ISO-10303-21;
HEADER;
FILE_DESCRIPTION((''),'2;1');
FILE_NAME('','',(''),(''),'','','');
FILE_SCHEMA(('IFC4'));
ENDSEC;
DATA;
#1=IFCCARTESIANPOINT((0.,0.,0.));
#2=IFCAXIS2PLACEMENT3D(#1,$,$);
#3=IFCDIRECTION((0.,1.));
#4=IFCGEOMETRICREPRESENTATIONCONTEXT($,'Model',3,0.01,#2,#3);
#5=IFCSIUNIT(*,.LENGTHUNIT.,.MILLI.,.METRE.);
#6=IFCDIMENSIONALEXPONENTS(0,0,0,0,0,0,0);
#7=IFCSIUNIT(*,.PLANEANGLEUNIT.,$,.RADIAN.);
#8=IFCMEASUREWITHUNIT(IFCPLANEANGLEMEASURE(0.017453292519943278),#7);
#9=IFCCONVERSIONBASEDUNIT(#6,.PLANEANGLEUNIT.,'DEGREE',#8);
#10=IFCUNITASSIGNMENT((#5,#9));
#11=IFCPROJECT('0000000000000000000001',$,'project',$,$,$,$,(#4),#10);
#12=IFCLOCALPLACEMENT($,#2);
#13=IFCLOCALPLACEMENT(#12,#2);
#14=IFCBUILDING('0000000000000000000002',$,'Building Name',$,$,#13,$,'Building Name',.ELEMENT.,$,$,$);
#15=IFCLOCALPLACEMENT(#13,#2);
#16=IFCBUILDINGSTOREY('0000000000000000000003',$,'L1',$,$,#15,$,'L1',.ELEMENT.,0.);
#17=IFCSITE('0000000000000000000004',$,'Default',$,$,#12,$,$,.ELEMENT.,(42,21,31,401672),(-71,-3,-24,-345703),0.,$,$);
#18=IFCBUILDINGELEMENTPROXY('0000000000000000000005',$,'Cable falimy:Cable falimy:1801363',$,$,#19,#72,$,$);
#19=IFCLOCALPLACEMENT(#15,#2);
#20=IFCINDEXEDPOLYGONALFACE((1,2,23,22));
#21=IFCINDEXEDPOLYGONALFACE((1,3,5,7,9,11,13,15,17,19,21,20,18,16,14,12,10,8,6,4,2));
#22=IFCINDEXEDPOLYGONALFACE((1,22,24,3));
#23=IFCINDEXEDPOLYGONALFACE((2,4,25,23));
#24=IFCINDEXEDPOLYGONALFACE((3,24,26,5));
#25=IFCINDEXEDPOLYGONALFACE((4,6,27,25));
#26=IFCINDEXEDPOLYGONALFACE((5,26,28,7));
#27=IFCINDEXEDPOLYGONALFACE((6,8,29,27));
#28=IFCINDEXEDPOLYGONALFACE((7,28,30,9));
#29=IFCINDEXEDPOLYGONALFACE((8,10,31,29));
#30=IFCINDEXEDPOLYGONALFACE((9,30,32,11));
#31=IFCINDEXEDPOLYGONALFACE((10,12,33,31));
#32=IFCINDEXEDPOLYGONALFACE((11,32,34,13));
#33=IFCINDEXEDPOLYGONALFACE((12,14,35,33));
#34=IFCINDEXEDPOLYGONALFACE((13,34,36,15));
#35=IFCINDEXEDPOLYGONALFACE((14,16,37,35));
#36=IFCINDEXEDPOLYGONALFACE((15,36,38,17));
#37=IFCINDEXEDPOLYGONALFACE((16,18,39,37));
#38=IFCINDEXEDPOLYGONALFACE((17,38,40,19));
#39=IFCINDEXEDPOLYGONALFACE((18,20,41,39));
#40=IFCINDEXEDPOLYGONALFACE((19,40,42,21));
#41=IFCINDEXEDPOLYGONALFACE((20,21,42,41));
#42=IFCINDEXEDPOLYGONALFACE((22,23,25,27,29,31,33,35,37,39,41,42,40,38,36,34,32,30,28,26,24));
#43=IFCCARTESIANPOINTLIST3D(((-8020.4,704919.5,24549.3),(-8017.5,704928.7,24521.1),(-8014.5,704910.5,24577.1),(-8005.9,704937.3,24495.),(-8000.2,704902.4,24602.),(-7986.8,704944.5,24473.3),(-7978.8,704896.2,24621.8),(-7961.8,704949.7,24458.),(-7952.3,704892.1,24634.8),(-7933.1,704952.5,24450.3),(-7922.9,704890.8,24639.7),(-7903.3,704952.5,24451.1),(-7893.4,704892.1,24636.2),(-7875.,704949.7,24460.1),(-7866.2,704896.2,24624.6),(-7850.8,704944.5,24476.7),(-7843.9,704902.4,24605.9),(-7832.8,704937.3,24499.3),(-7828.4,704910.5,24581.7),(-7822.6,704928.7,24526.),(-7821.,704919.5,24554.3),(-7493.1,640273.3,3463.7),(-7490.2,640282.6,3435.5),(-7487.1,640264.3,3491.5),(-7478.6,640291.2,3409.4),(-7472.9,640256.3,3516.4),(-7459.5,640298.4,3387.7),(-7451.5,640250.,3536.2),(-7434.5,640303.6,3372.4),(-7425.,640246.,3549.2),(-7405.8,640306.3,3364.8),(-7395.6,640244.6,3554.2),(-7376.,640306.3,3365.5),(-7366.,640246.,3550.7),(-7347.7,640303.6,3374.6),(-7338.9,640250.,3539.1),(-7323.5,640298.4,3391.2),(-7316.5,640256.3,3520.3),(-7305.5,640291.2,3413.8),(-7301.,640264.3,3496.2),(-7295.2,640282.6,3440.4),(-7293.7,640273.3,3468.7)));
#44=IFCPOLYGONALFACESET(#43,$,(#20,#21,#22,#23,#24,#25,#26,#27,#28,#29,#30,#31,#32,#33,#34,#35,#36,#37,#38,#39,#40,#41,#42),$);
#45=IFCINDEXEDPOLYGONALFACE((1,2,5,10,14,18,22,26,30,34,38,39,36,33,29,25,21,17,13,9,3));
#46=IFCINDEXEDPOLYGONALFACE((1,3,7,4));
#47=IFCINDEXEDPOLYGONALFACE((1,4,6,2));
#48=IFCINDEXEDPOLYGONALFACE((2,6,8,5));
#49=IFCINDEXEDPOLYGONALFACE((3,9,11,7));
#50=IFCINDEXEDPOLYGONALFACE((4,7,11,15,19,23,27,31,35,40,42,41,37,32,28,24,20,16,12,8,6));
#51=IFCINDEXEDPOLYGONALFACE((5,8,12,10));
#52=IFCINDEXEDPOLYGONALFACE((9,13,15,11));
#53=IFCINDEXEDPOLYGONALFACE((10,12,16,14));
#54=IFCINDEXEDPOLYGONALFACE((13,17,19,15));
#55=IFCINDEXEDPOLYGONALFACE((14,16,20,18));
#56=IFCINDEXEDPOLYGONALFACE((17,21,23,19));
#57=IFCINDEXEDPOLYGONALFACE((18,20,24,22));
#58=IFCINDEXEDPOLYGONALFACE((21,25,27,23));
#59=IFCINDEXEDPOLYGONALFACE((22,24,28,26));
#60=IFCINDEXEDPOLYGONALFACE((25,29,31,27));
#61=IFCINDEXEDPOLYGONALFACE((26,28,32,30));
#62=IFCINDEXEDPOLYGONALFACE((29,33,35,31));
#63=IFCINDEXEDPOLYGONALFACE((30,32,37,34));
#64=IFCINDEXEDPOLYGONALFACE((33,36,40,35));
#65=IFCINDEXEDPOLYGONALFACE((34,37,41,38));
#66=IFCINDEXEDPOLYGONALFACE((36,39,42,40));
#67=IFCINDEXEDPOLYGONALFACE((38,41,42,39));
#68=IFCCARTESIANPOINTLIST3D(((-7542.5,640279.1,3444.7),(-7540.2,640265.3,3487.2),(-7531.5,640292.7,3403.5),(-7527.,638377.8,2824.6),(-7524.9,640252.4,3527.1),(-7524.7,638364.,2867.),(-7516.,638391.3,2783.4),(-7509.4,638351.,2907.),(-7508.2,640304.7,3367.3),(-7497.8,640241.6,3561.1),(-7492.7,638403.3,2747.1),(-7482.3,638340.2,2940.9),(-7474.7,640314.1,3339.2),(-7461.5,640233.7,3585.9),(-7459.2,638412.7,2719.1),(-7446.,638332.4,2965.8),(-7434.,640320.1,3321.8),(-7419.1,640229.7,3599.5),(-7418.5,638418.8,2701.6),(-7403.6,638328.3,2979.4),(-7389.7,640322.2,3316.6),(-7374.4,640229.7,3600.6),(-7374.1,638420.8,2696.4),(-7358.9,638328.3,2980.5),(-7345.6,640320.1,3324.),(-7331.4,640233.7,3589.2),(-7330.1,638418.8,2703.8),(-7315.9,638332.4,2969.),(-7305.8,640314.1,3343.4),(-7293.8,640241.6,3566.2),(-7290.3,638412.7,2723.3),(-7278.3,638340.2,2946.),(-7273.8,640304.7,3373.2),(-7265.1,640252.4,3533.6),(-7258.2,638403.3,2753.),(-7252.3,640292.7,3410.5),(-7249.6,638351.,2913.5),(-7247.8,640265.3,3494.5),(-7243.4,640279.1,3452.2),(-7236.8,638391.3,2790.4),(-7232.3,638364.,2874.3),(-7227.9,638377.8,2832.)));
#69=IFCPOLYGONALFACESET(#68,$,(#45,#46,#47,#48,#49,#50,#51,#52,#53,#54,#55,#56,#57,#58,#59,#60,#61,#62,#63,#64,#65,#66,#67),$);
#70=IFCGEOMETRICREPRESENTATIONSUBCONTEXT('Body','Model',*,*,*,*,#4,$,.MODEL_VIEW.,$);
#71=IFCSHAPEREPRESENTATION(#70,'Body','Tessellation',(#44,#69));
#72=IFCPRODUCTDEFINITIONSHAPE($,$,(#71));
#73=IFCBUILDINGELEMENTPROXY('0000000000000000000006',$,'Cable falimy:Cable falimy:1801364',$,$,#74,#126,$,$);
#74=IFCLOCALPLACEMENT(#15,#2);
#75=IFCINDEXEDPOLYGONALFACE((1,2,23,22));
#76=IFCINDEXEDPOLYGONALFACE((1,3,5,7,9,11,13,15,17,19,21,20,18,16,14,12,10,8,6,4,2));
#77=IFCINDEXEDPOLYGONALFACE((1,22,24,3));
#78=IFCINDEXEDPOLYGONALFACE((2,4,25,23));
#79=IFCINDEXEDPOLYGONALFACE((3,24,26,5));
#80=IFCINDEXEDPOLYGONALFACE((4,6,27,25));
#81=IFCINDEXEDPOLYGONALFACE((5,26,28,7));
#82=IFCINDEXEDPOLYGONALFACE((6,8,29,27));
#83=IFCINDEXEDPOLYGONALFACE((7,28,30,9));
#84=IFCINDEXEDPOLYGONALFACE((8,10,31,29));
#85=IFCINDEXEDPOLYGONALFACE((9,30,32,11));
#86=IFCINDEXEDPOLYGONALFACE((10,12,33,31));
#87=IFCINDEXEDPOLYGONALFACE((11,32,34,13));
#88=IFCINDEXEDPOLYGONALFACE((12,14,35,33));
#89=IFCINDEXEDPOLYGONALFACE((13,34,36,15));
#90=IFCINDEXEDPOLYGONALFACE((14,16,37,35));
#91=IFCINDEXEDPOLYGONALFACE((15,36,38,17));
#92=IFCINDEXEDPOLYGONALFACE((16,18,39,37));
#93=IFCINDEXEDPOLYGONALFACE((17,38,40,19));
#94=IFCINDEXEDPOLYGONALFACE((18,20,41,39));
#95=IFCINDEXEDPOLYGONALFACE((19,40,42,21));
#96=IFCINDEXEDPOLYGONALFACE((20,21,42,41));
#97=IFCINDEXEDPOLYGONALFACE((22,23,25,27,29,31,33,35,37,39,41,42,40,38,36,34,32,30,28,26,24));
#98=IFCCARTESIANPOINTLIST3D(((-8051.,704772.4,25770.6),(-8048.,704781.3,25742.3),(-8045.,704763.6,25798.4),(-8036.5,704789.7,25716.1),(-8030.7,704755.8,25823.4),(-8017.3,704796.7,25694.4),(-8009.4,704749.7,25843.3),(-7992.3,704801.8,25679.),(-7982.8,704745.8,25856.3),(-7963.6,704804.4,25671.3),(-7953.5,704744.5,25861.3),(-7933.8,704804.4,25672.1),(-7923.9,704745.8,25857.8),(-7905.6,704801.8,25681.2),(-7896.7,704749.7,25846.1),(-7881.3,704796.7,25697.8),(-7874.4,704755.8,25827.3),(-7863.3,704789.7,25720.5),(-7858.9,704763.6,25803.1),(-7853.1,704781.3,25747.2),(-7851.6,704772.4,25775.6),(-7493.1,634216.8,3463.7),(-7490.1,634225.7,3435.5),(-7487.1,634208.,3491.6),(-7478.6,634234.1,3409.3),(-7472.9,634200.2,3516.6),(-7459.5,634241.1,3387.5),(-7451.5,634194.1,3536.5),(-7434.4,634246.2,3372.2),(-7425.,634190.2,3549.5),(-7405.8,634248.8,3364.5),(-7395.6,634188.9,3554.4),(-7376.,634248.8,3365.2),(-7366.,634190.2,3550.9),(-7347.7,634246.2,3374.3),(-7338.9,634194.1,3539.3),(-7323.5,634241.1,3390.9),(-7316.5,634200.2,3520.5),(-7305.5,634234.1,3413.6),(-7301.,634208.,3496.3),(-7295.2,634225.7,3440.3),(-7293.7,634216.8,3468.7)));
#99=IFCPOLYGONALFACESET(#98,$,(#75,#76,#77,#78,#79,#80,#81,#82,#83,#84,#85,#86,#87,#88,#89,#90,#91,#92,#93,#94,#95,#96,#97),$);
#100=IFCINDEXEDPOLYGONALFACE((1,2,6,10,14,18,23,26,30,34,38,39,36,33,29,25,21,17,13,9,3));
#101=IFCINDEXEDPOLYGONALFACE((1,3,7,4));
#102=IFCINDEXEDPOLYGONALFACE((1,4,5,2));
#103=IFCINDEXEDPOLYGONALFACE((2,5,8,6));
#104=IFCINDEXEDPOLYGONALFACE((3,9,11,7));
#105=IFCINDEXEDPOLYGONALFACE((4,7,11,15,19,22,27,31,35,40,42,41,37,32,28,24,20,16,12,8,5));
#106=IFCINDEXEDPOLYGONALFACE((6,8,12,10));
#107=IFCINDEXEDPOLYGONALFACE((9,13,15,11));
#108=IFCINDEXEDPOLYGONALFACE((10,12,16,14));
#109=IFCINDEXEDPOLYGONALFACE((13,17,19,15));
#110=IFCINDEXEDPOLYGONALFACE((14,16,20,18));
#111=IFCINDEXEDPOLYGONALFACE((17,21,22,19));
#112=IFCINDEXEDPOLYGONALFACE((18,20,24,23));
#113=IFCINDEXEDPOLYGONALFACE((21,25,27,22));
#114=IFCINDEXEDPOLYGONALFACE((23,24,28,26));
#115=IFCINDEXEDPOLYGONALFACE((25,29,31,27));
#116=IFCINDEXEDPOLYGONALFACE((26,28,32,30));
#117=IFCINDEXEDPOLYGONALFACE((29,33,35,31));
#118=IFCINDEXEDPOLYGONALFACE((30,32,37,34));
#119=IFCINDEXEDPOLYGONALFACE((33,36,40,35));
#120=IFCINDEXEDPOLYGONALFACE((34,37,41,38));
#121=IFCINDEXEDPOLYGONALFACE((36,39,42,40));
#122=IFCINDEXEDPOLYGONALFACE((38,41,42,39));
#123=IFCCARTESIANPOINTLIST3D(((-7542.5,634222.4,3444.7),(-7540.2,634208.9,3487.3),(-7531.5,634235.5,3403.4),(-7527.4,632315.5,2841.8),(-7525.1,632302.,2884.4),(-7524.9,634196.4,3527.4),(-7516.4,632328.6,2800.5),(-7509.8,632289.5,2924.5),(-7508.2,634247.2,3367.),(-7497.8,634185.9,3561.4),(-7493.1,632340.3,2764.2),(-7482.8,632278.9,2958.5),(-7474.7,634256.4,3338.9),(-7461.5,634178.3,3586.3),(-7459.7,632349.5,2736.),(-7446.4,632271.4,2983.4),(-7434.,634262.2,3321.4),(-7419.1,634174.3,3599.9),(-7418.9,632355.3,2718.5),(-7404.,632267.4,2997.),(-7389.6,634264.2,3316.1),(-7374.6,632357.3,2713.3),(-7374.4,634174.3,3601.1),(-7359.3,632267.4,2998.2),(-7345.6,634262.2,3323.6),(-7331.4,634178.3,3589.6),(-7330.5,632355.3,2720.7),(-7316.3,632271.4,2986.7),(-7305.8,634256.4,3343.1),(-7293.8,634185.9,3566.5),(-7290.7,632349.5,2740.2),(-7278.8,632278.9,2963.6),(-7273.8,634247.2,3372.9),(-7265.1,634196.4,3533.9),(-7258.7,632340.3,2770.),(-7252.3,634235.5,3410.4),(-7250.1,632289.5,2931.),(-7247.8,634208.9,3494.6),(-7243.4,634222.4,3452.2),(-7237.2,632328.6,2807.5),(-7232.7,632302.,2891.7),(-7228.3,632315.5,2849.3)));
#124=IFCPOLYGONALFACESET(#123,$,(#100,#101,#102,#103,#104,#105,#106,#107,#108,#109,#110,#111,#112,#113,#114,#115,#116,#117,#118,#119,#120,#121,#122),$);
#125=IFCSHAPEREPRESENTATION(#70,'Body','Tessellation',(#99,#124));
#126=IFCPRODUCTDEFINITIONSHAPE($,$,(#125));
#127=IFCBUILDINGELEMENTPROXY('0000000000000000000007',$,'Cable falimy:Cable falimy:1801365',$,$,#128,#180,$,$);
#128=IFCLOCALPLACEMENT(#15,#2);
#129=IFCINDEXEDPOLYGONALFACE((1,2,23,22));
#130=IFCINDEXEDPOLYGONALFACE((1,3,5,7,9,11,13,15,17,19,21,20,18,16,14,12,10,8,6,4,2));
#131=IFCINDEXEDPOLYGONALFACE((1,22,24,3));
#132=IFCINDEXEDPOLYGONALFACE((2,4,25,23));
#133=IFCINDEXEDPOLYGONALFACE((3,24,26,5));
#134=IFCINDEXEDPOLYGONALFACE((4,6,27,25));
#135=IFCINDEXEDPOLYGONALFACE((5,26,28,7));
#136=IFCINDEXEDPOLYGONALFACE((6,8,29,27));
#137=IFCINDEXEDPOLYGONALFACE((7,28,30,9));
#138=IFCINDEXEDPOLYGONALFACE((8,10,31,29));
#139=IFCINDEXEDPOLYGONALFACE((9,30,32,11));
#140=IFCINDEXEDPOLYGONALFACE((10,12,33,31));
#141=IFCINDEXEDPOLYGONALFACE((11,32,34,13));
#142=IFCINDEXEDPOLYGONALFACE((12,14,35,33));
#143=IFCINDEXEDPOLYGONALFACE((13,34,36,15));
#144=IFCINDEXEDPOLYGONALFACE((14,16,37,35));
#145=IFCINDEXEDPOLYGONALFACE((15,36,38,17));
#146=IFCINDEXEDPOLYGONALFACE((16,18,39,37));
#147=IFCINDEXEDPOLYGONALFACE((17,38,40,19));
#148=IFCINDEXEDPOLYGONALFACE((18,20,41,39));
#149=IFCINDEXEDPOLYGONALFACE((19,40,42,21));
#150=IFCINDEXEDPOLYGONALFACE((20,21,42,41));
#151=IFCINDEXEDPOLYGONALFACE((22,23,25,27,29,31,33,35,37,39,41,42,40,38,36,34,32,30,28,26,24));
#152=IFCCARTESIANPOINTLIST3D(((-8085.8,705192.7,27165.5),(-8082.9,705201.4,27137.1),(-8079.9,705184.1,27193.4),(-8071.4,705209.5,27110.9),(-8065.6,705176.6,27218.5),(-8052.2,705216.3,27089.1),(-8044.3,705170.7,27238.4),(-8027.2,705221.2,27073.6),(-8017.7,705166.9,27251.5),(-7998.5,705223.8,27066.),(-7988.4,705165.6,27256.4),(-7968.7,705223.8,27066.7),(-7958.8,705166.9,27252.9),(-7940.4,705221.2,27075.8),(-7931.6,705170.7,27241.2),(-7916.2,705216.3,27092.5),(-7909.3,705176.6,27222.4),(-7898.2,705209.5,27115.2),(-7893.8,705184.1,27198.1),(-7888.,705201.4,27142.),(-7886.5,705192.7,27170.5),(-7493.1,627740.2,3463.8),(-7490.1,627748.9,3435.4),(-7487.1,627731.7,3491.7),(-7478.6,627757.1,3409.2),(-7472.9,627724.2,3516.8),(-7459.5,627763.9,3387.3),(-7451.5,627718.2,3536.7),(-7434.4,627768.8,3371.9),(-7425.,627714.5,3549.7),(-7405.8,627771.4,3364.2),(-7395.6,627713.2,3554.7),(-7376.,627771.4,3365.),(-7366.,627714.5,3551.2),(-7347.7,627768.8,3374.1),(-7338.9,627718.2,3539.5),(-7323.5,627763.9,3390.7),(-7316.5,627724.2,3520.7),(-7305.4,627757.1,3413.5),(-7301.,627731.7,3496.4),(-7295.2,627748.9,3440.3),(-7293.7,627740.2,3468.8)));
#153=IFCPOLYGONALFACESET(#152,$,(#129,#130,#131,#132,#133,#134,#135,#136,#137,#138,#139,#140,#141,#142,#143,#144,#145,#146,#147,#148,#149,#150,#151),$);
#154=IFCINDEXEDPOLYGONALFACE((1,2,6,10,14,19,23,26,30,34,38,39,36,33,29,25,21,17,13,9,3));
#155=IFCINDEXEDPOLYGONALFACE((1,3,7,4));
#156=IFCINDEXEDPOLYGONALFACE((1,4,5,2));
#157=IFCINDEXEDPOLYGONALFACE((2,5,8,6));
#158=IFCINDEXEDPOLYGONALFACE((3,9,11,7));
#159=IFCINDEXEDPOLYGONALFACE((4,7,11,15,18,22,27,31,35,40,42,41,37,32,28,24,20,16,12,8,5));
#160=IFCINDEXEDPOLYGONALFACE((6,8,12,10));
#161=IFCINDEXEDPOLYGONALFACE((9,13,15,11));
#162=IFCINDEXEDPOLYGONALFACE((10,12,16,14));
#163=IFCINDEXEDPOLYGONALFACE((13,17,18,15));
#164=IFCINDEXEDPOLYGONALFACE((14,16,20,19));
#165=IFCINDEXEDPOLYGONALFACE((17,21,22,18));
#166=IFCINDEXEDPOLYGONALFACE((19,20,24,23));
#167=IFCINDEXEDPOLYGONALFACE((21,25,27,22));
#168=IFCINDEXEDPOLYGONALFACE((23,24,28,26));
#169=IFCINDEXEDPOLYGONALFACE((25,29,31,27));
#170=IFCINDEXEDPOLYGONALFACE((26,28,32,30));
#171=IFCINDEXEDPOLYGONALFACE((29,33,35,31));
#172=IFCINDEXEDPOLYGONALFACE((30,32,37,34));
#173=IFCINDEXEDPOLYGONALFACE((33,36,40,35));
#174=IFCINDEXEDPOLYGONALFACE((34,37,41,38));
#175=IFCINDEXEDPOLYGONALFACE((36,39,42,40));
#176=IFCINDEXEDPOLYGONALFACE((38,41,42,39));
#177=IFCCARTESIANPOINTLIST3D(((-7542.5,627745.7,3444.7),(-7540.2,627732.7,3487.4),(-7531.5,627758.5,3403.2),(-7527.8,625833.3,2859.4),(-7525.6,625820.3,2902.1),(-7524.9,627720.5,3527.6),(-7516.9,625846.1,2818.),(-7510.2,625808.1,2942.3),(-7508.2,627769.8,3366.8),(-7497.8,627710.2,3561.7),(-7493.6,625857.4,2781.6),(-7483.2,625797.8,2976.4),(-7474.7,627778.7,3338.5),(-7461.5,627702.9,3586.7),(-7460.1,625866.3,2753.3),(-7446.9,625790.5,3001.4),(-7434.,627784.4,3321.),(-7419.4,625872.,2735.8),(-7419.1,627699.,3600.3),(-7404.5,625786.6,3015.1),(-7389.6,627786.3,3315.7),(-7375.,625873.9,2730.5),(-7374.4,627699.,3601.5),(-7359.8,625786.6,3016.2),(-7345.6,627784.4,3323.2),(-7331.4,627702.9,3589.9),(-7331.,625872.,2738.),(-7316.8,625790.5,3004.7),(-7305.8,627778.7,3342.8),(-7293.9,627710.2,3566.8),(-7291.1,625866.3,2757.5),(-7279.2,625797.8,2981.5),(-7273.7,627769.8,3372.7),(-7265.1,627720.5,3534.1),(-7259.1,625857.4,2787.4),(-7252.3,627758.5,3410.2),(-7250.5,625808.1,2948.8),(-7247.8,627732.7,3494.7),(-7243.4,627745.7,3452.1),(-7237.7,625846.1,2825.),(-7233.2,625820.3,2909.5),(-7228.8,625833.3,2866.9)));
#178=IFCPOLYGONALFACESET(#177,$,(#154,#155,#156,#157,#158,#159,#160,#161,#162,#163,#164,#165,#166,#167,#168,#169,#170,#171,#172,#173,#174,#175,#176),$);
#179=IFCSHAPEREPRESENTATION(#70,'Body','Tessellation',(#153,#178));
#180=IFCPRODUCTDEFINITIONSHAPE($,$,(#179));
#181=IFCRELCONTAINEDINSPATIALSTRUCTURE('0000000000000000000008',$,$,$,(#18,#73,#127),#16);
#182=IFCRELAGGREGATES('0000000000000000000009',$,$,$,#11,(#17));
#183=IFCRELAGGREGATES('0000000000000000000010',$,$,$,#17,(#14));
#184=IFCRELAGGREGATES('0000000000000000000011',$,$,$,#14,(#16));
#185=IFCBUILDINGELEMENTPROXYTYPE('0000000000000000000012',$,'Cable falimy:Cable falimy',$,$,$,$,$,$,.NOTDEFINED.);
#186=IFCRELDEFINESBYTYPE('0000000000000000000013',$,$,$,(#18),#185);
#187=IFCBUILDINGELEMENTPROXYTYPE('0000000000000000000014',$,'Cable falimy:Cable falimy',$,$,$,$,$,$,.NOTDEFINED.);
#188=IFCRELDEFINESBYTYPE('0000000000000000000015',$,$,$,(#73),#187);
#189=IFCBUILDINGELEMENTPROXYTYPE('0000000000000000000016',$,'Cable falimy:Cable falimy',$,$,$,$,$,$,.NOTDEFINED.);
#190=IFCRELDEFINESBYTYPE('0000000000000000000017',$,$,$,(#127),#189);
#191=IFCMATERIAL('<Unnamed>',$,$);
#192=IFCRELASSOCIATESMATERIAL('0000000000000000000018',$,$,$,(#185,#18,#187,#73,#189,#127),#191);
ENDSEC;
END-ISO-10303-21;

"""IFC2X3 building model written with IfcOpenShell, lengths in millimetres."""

from ifc_helpers import new_model, entity, si_unit, converted_unit, direction, frame, frame_2d, origin, place, context, subcontext, project, spatial, circle, extrude, source, transform, mapped, material, type_object, type_shapes, element, save


model = new_model("IFC2X3")

# Units and contexts
model_context = context("Model", 3, precision=0.01, world=origin(), true_north=direction((0.0, 1.0)))
body_context = subcontext(model_context, "Body", "Model", "MODEL_VIEW")
ifc_project = project(units=[si_unit("LENGTHUNIT", "METRE", prefix="MILLI"), converted_unit("PLANEANGLEUNIT", "DEGREE", entity("IfcPlaneAngleMeasure", 0.017453292519943278), si_unit("PLANEANGLEUNIT", "RADIAN"), dimensions=[0, 0, 0, 0, 0, 0, 0])], contexts=[model_context])

# Site, building, storey
site_placement = place(None, origin())
site = spatial("IfcSite", under=ifc_project, at=site_placement, Name="Default", CompositionType="ELEMENT", RefLatitude=(42, 21, 31, 401672), RefLongitude=(-71, -3, -24, -345703), RefElevation=0.0)
building_placement = place(site_placement, origin())
building = spatial("IfcBuilding", under=site, at=building_placement, Name="Building Name", LongName="Building Name", CompositionType="ELEMENT")
storey_placement = place(building_placement, origin())
storey = spatial("IfcBuildingStorey", under=building, at=storey_placement, Name="L1", LongName="L1", CompositionType="ELEMENT", Elevation=0.0)

# Shared definitions
ifc_material = material(Name="<Unnamed>")

# Building element proxies
building_element_proxy_type_1 = type_object("IfcBuildingElementProxyType", Name="Cable falimy:Cable falimy", PredefinedType="NOTDEFINED", material=ifc_material)
shared_shape_1 = source(origin(), body_context, "Body", "SweptSolid", [
    extrude(circle(Radius=100.0, at=frame_2d((0.0, 0.0), x_axis=(1.0, 0.0))), frame((0.0, 0.0, 0.0), z_axis=(0.950678, 0.0, 0.310179), x_axis=(-0.310179, 0.0, 0.950678)), (0.0, 0.0, 1.0), 68000.0),
    extrude(circle(Radius=150.0, at=frame_2d((0.0, 0.0), x_axis=(1.0, 0.0))), frame((-1901.4, 0.0, -620.4), z_axis=(0.950678, 0.0, 0.310179), x_axis=(0.310179, 0.0, -0.950678)), (0.0, 0.0, 1.0), 2000.0),
])
type_shapes(building_element_proxy_type_1, [shared_shape_1])
proxy_1_placement = place(storey_placement, frame((-7393.2, 640275.7, 3459.1), z_axis=(-0.025001, 0.0, 0.999687), x_axis=(0.0, 1.0, 0.0)))
element("IfcBuildingElementProxy", 1, at=proxy_1_placement, inside=storey, type_object=building_element_proxy_type_1, material=ifc_material, Name="Cable falimy:Cable falimy:1801363", context=body_context, shape_type="MappedRepresentation", body=[
    mapped(shared_shape_1, transform((0.0, 0.0, 0.0), scale=1.0)),
])
building_element_proxy_type_2 = type_object("IfcBuildingElementProxyType", Name="Cable falimy:Cable falimy", PredefinedType="NOTDEFINED", material=ifc_material)
shared_shape_2 = source(origin(), body_context, "Body", "SweptSolid", [
    extrude(circle(Radius=100.0, at=frame_2d((0.0, 0.0), x_axis=(1.0, 0.0))), frame((0.0, 0.0, 0.0), z_axis=(0.953454, 0.0, 0.301538), x_axis=(-0.301538, 0.0, 0.953454)), (0.0, 0.0, 1.0), 74000.0),
    extrude(circle(Radius=150.0, at=frame_2d((0.0, 0.0), x_axis=(1.0, 0.0))), frame((-1906.9, 0.0, -603.1), z_axis=(0.953454, 0.0, 0.301538), x_axis=(0.301538, 0.0, -0.953454)), (0.0, 0.0, 1.0), 2000.0),
])
type_shapes(building_element_proxy_type_2, [shared_shape_2])
proxy_2_placement = place(storey_placement, frame((-7393.2, 634219.0, 3459.1), z_axis=(-0.025001, 0.0, 0.999687), x_axis=(0.0, 1.0, 0.0)))
element("IfcBuildingElementProxy", 2, at=proxy_2_placement, inside=storey, type_object=building_element_proxy_type_2, material=ifc_material, Name="Cable falimy:Cable falimy:1801364", context=body_context, shape_type="MappedRepresentation", body=[
    mapped(shared_shape_2, transform((0.0, 0.0, 0.0), scale=1.0)),
])
building_element_proxy_type_3 = type_object("IfcBuildingElementProxyType", Name="Cable falimy:Cable falimy", PredefinedType="NOTDEFINED", material=ifc_material)
shared_shape_3 = source(origin(), body_context, "Body", "SweptSolid", [
    extrude(circle(Radius=100.0, at=frame_2d((0.0, 0.0), x_axis=(1.0, 0.0))), frame((0.0, 0.0, 0.0), z_axis=(0.956203, 0.0, 0.292706), x_axis=(-0.292706, 0.0, 0.956203)), (0.0, 0.0, 1.0), 81000.0),
    extrude(circle(Radius=150.0, at=frame_2d((0.0, 0.0), x_axis=(1.0, 0.0))), frame((-1912.4, 0.0, -585.4), z_axis=(0.956203, 0.0, 0.292706), x_axis=(0.292706, 0.0, -0.956203)), (0.0, 0.0, 1.0), 2000.0),
])
type_shapes(building_element_proxy_type_3, [shared_shape_3])
proxy_3_placement = place(storey_placement, frame((-7393.2, 627742.4, 3459.1), z_axis=(-0.025001, 0.0, 0.999687), x_axis=(0.0, 1.0, 0.0)))
element("IfcBuildingElementProxy", 3, at=proxy_3_placement, inside=storey, type_object=building_element_proxy_type_3, material=ifc_material, Name="Cable falimy:Cable falimy:1801365", context=body_context, shape_type="MappedRepresentation", body=[
    mapped(shared_shape_3, transform((0.0, 0.0, 0.0), scale=1.0)),
])

save(model, "model.ifc")
